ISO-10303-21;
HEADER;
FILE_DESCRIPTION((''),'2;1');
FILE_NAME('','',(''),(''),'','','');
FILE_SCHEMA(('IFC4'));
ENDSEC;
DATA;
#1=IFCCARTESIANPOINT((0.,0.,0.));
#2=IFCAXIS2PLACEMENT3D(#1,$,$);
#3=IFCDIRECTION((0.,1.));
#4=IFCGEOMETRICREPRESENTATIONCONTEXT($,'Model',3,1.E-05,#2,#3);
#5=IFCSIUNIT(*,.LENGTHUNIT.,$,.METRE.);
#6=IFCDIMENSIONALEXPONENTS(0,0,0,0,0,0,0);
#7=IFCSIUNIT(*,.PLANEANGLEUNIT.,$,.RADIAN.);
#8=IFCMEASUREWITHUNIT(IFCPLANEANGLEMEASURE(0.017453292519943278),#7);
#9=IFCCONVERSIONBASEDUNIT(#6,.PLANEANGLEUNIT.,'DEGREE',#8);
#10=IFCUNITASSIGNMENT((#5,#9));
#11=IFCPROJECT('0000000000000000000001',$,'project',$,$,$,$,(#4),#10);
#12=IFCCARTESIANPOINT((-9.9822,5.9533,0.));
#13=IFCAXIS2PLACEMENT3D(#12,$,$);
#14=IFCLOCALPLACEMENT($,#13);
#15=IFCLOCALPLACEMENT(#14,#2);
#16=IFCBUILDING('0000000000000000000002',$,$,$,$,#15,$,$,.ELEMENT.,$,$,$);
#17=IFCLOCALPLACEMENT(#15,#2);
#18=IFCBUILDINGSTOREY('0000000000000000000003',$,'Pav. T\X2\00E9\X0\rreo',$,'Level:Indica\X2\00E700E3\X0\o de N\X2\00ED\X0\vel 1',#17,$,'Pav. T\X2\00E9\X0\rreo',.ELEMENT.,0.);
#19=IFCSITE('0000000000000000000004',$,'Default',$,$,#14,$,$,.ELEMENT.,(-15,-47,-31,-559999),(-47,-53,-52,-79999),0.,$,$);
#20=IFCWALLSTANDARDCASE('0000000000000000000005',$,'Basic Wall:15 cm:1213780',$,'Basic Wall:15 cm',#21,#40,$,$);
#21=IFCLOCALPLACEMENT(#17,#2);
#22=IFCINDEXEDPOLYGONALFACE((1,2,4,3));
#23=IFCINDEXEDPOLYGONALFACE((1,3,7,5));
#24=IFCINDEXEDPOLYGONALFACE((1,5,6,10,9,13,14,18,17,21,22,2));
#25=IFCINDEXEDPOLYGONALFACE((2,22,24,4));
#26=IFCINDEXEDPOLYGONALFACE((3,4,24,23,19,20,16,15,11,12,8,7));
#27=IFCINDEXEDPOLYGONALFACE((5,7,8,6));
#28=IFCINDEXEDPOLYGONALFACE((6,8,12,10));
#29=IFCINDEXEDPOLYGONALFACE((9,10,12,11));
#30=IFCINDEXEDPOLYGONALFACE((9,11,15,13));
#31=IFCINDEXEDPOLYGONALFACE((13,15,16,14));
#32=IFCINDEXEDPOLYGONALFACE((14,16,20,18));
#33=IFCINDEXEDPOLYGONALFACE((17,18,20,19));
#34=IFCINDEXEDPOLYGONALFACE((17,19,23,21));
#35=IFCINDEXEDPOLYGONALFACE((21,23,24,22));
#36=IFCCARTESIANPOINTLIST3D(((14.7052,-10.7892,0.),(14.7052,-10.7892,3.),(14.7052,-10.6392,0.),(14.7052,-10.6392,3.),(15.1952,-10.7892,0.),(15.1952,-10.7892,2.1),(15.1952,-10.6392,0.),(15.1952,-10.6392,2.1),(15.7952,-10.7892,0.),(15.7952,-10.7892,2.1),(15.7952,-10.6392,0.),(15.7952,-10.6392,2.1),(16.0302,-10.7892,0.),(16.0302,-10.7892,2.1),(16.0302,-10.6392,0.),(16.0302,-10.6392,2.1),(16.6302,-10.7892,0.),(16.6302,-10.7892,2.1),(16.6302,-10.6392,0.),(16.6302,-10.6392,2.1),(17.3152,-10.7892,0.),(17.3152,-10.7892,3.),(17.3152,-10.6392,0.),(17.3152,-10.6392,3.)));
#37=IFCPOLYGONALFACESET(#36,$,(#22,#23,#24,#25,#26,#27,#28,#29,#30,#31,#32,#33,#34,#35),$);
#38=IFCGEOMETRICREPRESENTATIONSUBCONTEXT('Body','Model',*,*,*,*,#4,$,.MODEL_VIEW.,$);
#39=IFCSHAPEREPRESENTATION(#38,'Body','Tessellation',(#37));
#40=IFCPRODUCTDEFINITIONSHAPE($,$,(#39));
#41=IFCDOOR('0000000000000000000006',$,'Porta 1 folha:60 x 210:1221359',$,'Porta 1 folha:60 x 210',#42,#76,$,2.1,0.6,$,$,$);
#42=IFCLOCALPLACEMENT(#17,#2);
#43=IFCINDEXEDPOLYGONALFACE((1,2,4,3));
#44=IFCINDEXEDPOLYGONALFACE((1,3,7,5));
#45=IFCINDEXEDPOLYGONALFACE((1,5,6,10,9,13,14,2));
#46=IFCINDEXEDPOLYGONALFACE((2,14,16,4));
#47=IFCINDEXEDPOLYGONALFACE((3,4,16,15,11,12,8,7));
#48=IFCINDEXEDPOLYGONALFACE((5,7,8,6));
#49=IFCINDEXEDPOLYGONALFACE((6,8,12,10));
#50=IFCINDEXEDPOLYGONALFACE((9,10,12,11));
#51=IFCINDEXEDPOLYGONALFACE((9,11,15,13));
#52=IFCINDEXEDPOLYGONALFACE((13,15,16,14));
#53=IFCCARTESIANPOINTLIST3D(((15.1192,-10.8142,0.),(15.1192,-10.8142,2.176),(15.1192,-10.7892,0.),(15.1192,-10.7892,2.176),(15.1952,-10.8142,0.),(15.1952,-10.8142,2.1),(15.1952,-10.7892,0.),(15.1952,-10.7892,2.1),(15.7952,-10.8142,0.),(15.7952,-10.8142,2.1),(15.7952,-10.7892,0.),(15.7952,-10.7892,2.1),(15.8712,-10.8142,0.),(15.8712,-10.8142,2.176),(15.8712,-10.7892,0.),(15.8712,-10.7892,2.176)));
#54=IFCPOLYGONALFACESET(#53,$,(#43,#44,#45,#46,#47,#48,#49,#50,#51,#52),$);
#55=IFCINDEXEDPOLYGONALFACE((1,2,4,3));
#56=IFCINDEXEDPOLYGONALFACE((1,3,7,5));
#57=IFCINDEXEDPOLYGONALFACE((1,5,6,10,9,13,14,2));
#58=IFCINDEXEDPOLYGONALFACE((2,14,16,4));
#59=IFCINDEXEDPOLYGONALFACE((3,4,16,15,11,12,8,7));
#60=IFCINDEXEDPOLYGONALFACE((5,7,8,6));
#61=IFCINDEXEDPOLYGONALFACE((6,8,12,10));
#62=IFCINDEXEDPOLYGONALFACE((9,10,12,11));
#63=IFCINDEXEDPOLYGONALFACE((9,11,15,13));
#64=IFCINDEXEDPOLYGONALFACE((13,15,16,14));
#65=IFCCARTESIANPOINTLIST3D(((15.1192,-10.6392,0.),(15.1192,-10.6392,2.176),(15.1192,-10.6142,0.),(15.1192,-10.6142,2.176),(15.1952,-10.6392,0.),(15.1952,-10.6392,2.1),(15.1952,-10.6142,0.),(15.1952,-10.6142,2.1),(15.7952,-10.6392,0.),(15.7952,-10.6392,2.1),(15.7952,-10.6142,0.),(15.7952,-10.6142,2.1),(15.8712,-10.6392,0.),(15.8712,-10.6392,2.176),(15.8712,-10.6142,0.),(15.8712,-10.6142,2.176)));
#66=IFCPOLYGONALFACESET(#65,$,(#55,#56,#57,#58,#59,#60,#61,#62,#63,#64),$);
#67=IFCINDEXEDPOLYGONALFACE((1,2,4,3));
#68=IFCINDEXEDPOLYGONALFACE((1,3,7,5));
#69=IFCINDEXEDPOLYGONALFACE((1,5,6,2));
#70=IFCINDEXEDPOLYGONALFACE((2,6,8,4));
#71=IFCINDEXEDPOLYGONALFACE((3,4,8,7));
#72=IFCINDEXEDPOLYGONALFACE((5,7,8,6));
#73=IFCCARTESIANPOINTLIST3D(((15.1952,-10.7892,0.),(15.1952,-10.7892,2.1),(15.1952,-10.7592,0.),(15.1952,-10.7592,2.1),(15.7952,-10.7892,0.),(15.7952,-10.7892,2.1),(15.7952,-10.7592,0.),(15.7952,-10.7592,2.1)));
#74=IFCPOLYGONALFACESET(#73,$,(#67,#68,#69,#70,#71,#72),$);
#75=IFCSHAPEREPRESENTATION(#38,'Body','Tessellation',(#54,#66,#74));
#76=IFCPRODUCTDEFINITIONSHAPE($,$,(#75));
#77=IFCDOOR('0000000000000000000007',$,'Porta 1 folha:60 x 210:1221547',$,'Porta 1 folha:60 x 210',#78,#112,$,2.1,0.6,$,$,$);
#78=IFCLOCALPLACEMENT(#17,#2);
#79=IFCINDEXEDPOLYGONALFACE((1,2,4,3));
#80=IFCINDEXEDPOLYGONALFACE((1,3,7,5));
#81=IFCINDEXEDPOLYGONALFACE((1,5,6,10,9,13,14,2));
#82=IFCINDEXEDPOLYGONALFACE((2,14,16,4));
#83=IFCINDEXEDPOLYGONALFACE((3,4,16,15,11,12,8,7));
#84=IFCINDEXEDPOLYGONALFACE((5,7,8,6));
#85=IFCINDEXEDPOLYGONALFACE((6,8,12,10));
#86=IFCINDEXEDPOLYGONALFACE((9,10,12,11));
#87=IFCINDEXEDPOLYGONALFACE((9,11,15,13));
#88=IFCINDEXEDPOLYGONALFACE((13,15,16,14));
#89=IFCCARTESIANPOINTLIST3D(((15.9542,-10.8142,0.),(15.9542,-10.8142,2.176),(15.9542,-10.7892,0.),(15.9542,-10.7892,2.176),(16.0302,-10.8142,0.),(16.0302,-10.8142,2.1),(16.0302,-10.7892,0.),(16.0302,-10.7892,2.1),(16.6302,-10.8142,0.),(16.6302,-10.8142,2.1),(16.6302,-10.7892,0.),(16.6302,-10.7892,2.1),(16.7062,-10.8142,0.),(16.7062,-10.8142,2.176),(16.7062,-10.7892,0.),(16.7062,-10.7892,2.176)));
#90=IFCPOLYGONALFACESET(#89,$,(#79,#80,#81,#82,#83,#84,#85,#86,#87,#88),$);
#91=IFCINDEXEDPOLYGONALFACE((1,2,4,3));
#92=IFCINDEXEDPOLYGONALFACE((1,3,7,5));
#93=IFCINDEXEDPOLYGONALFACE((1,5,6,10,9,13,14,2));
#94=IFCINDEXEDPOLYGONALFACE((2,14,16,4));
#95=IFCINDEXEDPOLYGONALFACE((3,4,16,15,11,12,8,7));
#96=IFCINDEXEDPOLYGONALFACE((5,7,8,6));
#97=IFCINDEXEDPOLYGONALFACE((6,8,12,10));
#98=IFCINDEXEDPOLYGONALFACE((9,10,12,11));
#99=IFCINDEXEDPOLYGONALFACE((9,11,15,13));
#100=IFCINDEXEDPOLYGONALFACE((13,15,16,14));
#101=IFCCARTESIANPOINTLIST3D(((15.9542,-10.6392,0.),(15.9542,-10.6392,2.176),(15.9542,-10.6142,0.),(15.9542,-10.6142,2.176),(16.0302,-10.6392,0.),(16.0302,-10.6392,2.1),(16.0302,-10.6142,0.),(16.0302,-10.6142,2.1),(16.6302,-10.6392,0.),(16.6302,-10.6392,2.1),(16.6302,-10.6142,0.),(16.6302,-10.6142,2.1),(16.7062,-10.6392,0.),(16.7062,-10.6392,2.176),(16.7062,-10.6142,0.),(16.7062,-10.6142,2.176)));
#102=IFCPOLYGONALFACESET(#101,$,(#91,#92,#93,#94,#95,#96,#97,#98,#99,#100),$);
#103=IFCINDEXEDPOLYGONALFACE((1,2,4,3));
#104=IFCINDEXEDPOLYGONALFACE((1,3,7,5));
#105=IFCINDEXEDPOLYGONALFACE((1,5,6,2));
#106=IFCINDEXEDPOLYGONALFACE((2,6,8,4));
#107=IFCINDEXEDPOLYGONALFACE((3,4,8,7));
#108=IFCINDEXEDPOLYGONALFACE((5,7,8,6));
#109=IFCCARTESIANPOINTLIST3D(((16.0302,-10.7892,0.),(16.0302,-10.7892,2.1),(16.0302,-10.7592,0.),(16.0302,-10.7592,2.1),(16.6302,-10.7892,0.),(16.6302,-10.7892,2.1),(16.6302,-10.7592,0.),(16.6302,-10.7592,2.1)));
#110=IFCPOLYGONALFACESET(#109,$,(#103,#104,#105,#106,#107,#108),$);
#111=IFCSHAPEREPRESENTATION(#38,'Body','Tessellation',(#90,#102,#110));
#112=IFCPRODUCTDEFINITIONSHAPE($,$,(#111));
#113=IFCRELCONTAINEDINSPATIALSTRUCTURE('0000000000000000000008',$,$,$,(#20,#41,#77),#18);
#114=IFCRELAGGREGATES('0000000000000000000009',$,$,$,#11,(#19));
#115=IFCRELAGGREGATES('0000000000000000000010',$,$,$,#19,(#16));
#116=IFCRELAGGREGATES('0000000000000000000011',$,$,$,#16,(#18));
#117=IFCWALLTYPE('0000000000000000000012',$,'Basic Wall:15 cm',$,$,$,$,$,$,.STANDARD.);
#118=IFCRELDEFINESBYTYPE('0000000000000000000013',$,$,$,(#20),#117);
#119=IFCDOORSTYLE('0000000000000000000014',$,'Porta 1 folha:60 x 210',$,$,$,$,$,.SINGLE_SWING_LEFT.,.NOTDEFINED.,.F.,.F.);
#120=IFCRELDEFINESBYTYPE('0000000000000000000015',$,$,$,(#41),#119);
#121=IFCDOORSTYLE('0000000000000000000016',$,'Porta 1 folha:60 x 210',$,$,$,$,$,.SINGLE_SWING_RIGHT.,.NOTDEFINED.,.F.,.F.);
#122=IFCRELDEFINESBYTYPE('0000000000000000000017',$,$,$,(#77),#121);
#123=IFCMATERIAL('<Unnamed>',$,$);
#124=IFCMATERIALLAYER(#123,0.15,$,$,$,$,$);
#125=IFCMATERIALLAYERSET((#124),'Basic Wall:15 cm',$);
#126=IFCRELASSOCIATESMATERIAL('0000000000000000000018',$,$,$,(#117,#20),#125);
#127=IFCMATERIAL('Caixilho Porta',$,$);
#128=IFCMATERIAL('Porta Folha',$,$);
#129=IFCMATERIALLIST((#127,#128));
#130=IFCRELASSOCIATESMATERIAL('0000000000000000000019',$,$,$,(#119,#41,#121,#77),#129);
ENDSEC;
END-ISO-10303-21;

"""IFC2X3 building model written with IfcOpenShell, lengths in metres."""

from ifc_helpers import new_model, entity, si_unit, converted_unit, direction, frame, frame_2d, origin, origin_2d_with_axis, place, context, subcontext, project, spatial, polyline, rectangle, outline, extrude, source, transform, mapped, material, material_list, layer, layer_set, layer_usage, type_object, type_shapes, element, fill, save


model = new_model("IFC2X3")

# Units and contexts
model_context = context("Model", 3, precision=1e-05, world=origin(), true_north=direction((0.0, 1.0)))
body_context = subcontext(model_context, "Body", "Model", "MODEL_VIEW")
ifc_project = project(units=[si_unit("LENGTHUNIT", "METRE"), converted_unit("PLANEANGLEUNIT", "DEGREE", entity("IfcPlaneAngleMeasure", 0.017453292519943278), si_unit("PLANEANGLEUNIT", "RADIAN"), dimensions=[0, 0, 0, 0, 0, 0, 0])], contexts=[model_context])

# Site, building, storey
site_placement = place(None, frame((-9.9822, 5.9533, 0.0)))
site = spatial("IfcSite", under=ifc_project, at=site_placement, Name="Default", CompositionType="ELEMENT", RefLatitude=(-15, -47, -31, -559999), RefLongitude=(-47, -53, -52, -79999), RefElevation=0.0)
building_placement = place(site_placement, origin())
building = spatial("IfcBuilding", under=site, at=building_placement, CompositionType="ELEMENT")
storey_placement = place(building_placement, origin())
storey = spatial("IfcBuildingStorey", under=building, at=storey_placement, Name="Pav. Térreo", ObjectType="Level:Indicação de Nível 1", LongName="Pav. Térreo", CompositionType="ELEMENT", Elevation=0.0)

# Shared definitions
ifc_material_1 = material(Name="<Unnamed>")
ifc_layer_1 = layer(ifc_material_1, 0.15)
ifc_layer_set_1 = layer_set([ifc_layer_1], Name="Basic Wall:15 cm")
wall_type = type_object("IfcWallType", Name="Basic Wall:15 cm", PredefinedType="STANDARD", material=ifc_layer_set_1)

# Shared definitions
ifc_material_2 = material(Name="Caixilho Porta")
ifc_material_3 = material(Name="Porta Folha")
ifc_material_list_1 = material_list([ifc_material_2, ifc_material_3])

# Wall, openings, doors
ifc_layer_usage_1 = layer_usage(ifc_layer_set_1, "AXIS2", "NEGATIVE", 0.075)
wall_1_placement = place(storey_placement, frame((14.7052, -10.7142, 0.0)))
wall_1 = element("IfcWallStandardCase", 1, at=wall_1_placement, inside=storey, type_object=wall_type, material=ifc_layer_usage_1, Name="Basic Wall:15 cm:1213780", ObjectType="Basic Wall:15 cm", context=body_context, shape_type="SweptSolid", body=[
    extrude(rectangle(XDim=2.61, YDim=0.15, at=frame_2d((1.305, 0.0), x_axis=(1.0, 0.0))), origin(), (0.0, 0.0, 1.0), 3.0),
])
opening_1_placement = place(wall_1_placement, frame((1.09, 0.075, 0.0)))
opening_1 = element("IfcOpeningElement", 2, at=opening_1_placement, cuts=wall_1, ObjectType="Opening", context=body_context, shape_type="SweptSolid", body=[
    extrude(rectangle(XDim=0.6, YDim=2.1, at=frame_2d((1.05, 0.3), x_axis=(0.0, -1.0))), frame((0.0, 0.0, 0.0), z_axis=(0.0, -1.0, 0.0), x_axis=(0.0, 0.0, 1.0)), (0.0, 0.0, 1.0), 0.15),
])
opening_2_placement = place(wall_1_placement, frame((1.925, 0.075, 0.0)))
opening_2 = element("IfcOpeningElement", 3, at=opening_2_placement, cuts=wall_1, ObjectType="Opening", context=body_context, shape_type="SweptSolid", body=[
    extrude(rectangle(XDim=0.6, YDim=2.1, at=frame_2d((1.05, 0.3), x_axis=(0.0, 1.0))), frame((0.0, 0.0, 0.0), z_axis=(0.0, -1.0, 0.0), x_axis=(0.0, 0.0, 1.0)), (0.0, 0.0, 1.0), 0.15),
])
door_style_1 = type_object("IfcDoorStyle", Name="Porta 1 folha:60 x 210", ConstructionType="NOTDEFINED", OperationType="SINGLE_SWING_LEFT", ParameterTakesPrecedence=False, Sizeable=False, material=ifc_material_list_1)
shared_shape_1 = source(origin(), body_context, "Body", "SweptSolid", [
    extrude(outline(polyline([(-0.376, -1.107), (0.376, -1.107), (0.376, 1.069), (0.3, 1.069), (0.3, -1.031), (-0.3, -1.031), (-0.3, 1.069), (-0.376, 1.069), (-0.376, -1.107)])), frame((0.3, 0.175, 1.069), z_axis=(0.0, -1.0, 0.0), x_axis=(-1.0, 0.0, 0.0)), (0.0, 0.0, 1.0), 0.025),
    extrude(outline(polyline([(-1.107, -0.376), (1.069, -0.376), (1.069, -0.3), (-1.031, -0.3), (-1.031, 0.3), (1.069, 0.3), (1.069, 0.376), (-1.107, 0.376), (-1.107, -0.376)])), frame((0.3, 0.0, 1.069), z_axis=(0.0, -1.0, 0.0), x_axis=(0.0, 0.0, -1.0)), (0.0, 0.0, 1.0), 0.025),
    extrude(rectangle(XDim=0.6, YDim=0.03, at=origin_2d_with_axis()), frame((0.3, 0.135, 0.0)), (0.0, 0.0, 1.0), 2.1),
])
type_shapes(door_style_1, [shared_shape_1])
door_1_placement = place(opening_1_placement, frame((0.0, 0.0, 0.0), z_axis=(0.0, 0.0, 1.0), x_axis=(-1.0, 0.0, 0.0)))
door_1 = element("IfcDoor", 4, at=door_1_placement, inside=storey, type_object=door_style_1, material=ifc_material_list_1, Name="Porta 1 folha:60 x 210:1221359", ObjectType="Porta 1 folha:60 x 210", OverallHeight=2.1, OverallWidth=0.6, context=body_context, shape_type="MappedRepresentation", body=[
    mapped(shared_shape_1, transform((0.0, 0.0, 0.0), scale=1.0)),
])
fill(opening_1, door_1)
door_style_2 = type_object("IfcDoorStyle", Name="Porta 1 folha:60 x 210", ConstructionType="NOTDEFINED", OperationType="SINGLE_SWING_RIGHT", ParameterTakesPrecedence=False, Sizeable=False, material=ifc_material_list_1)
shared_shape_2 = source(origin(), body_context, "Body", "SweptSolid", [
    extrude(outline(polyline([(-0.376, -1.107), (0.376, -1.107), (0.376, 1.069), (0.3, 1.069), (0.3, -1.031), (-0.3, -1.031), (-0.3, 1.069), (-0.376, 1.069), (-0.376, -1.107)])), frame((0.3, 0.15, 1.069), z_axis=(0.0, 1.0, 0.0), x_axis=(1.0, 0.0, 0.0)), (0.0, 0.0, 1.0), 0.025),
    extrude(outline(polyline([(-1.107, -0.376), (1.069, -0.376), (1.069, -0.3), (-1.031, -0.3), (-1.031, 0.3), (1.069, 0.3), (1.069, 0.376), (-1.107, 0.376), (-1.107, -0.376)])), frame((0.3, -0.025, 1.069), z_axis=(0.0, 1.0, 0.0), x_axis=(0.0, 0.0, -1.0)), (0.0, 0.0, 1.0), 0.025),
    extrude(rectangle(XDim=0.03, YDim=0.6, at=origin_2d_with_axis()), frame((0.3, 0.135, 0.0), z_axis=(0.0, 0.0, 1.0), x_axis=(0.0, 1.0, 0.0)), (0.0, 0.0, 1.0), 2.1),
])
type_shapes(door_style_2, [shared_shape_2])
door_2_placement = place(opening_2_placement, frame((0.0, 0.0, 0.0), z_axis=(0.0, 0.0, 1.0), x_axis=(-1.0, 0.0, 0.0)))
door_2 = element("IfcDoor", 5, at=door_2_placement, inside=storey, type_object=door_style_2, material=ifc_material_list_1, Name="Porta 1 folha:60 x 210:1221547", ObjectType="Porta 1 folha:60 x 210", OverallHeight=2.1, OverallWidth=0.6, context=body_context, shape_type="MappedRepresentation", body=[
    mapped(shared_shape_2, transform((0.0, 0.0, 0.0), scale=1.0)),
])
fill(opening_2, door_2)

save(model, "model.ifc")
